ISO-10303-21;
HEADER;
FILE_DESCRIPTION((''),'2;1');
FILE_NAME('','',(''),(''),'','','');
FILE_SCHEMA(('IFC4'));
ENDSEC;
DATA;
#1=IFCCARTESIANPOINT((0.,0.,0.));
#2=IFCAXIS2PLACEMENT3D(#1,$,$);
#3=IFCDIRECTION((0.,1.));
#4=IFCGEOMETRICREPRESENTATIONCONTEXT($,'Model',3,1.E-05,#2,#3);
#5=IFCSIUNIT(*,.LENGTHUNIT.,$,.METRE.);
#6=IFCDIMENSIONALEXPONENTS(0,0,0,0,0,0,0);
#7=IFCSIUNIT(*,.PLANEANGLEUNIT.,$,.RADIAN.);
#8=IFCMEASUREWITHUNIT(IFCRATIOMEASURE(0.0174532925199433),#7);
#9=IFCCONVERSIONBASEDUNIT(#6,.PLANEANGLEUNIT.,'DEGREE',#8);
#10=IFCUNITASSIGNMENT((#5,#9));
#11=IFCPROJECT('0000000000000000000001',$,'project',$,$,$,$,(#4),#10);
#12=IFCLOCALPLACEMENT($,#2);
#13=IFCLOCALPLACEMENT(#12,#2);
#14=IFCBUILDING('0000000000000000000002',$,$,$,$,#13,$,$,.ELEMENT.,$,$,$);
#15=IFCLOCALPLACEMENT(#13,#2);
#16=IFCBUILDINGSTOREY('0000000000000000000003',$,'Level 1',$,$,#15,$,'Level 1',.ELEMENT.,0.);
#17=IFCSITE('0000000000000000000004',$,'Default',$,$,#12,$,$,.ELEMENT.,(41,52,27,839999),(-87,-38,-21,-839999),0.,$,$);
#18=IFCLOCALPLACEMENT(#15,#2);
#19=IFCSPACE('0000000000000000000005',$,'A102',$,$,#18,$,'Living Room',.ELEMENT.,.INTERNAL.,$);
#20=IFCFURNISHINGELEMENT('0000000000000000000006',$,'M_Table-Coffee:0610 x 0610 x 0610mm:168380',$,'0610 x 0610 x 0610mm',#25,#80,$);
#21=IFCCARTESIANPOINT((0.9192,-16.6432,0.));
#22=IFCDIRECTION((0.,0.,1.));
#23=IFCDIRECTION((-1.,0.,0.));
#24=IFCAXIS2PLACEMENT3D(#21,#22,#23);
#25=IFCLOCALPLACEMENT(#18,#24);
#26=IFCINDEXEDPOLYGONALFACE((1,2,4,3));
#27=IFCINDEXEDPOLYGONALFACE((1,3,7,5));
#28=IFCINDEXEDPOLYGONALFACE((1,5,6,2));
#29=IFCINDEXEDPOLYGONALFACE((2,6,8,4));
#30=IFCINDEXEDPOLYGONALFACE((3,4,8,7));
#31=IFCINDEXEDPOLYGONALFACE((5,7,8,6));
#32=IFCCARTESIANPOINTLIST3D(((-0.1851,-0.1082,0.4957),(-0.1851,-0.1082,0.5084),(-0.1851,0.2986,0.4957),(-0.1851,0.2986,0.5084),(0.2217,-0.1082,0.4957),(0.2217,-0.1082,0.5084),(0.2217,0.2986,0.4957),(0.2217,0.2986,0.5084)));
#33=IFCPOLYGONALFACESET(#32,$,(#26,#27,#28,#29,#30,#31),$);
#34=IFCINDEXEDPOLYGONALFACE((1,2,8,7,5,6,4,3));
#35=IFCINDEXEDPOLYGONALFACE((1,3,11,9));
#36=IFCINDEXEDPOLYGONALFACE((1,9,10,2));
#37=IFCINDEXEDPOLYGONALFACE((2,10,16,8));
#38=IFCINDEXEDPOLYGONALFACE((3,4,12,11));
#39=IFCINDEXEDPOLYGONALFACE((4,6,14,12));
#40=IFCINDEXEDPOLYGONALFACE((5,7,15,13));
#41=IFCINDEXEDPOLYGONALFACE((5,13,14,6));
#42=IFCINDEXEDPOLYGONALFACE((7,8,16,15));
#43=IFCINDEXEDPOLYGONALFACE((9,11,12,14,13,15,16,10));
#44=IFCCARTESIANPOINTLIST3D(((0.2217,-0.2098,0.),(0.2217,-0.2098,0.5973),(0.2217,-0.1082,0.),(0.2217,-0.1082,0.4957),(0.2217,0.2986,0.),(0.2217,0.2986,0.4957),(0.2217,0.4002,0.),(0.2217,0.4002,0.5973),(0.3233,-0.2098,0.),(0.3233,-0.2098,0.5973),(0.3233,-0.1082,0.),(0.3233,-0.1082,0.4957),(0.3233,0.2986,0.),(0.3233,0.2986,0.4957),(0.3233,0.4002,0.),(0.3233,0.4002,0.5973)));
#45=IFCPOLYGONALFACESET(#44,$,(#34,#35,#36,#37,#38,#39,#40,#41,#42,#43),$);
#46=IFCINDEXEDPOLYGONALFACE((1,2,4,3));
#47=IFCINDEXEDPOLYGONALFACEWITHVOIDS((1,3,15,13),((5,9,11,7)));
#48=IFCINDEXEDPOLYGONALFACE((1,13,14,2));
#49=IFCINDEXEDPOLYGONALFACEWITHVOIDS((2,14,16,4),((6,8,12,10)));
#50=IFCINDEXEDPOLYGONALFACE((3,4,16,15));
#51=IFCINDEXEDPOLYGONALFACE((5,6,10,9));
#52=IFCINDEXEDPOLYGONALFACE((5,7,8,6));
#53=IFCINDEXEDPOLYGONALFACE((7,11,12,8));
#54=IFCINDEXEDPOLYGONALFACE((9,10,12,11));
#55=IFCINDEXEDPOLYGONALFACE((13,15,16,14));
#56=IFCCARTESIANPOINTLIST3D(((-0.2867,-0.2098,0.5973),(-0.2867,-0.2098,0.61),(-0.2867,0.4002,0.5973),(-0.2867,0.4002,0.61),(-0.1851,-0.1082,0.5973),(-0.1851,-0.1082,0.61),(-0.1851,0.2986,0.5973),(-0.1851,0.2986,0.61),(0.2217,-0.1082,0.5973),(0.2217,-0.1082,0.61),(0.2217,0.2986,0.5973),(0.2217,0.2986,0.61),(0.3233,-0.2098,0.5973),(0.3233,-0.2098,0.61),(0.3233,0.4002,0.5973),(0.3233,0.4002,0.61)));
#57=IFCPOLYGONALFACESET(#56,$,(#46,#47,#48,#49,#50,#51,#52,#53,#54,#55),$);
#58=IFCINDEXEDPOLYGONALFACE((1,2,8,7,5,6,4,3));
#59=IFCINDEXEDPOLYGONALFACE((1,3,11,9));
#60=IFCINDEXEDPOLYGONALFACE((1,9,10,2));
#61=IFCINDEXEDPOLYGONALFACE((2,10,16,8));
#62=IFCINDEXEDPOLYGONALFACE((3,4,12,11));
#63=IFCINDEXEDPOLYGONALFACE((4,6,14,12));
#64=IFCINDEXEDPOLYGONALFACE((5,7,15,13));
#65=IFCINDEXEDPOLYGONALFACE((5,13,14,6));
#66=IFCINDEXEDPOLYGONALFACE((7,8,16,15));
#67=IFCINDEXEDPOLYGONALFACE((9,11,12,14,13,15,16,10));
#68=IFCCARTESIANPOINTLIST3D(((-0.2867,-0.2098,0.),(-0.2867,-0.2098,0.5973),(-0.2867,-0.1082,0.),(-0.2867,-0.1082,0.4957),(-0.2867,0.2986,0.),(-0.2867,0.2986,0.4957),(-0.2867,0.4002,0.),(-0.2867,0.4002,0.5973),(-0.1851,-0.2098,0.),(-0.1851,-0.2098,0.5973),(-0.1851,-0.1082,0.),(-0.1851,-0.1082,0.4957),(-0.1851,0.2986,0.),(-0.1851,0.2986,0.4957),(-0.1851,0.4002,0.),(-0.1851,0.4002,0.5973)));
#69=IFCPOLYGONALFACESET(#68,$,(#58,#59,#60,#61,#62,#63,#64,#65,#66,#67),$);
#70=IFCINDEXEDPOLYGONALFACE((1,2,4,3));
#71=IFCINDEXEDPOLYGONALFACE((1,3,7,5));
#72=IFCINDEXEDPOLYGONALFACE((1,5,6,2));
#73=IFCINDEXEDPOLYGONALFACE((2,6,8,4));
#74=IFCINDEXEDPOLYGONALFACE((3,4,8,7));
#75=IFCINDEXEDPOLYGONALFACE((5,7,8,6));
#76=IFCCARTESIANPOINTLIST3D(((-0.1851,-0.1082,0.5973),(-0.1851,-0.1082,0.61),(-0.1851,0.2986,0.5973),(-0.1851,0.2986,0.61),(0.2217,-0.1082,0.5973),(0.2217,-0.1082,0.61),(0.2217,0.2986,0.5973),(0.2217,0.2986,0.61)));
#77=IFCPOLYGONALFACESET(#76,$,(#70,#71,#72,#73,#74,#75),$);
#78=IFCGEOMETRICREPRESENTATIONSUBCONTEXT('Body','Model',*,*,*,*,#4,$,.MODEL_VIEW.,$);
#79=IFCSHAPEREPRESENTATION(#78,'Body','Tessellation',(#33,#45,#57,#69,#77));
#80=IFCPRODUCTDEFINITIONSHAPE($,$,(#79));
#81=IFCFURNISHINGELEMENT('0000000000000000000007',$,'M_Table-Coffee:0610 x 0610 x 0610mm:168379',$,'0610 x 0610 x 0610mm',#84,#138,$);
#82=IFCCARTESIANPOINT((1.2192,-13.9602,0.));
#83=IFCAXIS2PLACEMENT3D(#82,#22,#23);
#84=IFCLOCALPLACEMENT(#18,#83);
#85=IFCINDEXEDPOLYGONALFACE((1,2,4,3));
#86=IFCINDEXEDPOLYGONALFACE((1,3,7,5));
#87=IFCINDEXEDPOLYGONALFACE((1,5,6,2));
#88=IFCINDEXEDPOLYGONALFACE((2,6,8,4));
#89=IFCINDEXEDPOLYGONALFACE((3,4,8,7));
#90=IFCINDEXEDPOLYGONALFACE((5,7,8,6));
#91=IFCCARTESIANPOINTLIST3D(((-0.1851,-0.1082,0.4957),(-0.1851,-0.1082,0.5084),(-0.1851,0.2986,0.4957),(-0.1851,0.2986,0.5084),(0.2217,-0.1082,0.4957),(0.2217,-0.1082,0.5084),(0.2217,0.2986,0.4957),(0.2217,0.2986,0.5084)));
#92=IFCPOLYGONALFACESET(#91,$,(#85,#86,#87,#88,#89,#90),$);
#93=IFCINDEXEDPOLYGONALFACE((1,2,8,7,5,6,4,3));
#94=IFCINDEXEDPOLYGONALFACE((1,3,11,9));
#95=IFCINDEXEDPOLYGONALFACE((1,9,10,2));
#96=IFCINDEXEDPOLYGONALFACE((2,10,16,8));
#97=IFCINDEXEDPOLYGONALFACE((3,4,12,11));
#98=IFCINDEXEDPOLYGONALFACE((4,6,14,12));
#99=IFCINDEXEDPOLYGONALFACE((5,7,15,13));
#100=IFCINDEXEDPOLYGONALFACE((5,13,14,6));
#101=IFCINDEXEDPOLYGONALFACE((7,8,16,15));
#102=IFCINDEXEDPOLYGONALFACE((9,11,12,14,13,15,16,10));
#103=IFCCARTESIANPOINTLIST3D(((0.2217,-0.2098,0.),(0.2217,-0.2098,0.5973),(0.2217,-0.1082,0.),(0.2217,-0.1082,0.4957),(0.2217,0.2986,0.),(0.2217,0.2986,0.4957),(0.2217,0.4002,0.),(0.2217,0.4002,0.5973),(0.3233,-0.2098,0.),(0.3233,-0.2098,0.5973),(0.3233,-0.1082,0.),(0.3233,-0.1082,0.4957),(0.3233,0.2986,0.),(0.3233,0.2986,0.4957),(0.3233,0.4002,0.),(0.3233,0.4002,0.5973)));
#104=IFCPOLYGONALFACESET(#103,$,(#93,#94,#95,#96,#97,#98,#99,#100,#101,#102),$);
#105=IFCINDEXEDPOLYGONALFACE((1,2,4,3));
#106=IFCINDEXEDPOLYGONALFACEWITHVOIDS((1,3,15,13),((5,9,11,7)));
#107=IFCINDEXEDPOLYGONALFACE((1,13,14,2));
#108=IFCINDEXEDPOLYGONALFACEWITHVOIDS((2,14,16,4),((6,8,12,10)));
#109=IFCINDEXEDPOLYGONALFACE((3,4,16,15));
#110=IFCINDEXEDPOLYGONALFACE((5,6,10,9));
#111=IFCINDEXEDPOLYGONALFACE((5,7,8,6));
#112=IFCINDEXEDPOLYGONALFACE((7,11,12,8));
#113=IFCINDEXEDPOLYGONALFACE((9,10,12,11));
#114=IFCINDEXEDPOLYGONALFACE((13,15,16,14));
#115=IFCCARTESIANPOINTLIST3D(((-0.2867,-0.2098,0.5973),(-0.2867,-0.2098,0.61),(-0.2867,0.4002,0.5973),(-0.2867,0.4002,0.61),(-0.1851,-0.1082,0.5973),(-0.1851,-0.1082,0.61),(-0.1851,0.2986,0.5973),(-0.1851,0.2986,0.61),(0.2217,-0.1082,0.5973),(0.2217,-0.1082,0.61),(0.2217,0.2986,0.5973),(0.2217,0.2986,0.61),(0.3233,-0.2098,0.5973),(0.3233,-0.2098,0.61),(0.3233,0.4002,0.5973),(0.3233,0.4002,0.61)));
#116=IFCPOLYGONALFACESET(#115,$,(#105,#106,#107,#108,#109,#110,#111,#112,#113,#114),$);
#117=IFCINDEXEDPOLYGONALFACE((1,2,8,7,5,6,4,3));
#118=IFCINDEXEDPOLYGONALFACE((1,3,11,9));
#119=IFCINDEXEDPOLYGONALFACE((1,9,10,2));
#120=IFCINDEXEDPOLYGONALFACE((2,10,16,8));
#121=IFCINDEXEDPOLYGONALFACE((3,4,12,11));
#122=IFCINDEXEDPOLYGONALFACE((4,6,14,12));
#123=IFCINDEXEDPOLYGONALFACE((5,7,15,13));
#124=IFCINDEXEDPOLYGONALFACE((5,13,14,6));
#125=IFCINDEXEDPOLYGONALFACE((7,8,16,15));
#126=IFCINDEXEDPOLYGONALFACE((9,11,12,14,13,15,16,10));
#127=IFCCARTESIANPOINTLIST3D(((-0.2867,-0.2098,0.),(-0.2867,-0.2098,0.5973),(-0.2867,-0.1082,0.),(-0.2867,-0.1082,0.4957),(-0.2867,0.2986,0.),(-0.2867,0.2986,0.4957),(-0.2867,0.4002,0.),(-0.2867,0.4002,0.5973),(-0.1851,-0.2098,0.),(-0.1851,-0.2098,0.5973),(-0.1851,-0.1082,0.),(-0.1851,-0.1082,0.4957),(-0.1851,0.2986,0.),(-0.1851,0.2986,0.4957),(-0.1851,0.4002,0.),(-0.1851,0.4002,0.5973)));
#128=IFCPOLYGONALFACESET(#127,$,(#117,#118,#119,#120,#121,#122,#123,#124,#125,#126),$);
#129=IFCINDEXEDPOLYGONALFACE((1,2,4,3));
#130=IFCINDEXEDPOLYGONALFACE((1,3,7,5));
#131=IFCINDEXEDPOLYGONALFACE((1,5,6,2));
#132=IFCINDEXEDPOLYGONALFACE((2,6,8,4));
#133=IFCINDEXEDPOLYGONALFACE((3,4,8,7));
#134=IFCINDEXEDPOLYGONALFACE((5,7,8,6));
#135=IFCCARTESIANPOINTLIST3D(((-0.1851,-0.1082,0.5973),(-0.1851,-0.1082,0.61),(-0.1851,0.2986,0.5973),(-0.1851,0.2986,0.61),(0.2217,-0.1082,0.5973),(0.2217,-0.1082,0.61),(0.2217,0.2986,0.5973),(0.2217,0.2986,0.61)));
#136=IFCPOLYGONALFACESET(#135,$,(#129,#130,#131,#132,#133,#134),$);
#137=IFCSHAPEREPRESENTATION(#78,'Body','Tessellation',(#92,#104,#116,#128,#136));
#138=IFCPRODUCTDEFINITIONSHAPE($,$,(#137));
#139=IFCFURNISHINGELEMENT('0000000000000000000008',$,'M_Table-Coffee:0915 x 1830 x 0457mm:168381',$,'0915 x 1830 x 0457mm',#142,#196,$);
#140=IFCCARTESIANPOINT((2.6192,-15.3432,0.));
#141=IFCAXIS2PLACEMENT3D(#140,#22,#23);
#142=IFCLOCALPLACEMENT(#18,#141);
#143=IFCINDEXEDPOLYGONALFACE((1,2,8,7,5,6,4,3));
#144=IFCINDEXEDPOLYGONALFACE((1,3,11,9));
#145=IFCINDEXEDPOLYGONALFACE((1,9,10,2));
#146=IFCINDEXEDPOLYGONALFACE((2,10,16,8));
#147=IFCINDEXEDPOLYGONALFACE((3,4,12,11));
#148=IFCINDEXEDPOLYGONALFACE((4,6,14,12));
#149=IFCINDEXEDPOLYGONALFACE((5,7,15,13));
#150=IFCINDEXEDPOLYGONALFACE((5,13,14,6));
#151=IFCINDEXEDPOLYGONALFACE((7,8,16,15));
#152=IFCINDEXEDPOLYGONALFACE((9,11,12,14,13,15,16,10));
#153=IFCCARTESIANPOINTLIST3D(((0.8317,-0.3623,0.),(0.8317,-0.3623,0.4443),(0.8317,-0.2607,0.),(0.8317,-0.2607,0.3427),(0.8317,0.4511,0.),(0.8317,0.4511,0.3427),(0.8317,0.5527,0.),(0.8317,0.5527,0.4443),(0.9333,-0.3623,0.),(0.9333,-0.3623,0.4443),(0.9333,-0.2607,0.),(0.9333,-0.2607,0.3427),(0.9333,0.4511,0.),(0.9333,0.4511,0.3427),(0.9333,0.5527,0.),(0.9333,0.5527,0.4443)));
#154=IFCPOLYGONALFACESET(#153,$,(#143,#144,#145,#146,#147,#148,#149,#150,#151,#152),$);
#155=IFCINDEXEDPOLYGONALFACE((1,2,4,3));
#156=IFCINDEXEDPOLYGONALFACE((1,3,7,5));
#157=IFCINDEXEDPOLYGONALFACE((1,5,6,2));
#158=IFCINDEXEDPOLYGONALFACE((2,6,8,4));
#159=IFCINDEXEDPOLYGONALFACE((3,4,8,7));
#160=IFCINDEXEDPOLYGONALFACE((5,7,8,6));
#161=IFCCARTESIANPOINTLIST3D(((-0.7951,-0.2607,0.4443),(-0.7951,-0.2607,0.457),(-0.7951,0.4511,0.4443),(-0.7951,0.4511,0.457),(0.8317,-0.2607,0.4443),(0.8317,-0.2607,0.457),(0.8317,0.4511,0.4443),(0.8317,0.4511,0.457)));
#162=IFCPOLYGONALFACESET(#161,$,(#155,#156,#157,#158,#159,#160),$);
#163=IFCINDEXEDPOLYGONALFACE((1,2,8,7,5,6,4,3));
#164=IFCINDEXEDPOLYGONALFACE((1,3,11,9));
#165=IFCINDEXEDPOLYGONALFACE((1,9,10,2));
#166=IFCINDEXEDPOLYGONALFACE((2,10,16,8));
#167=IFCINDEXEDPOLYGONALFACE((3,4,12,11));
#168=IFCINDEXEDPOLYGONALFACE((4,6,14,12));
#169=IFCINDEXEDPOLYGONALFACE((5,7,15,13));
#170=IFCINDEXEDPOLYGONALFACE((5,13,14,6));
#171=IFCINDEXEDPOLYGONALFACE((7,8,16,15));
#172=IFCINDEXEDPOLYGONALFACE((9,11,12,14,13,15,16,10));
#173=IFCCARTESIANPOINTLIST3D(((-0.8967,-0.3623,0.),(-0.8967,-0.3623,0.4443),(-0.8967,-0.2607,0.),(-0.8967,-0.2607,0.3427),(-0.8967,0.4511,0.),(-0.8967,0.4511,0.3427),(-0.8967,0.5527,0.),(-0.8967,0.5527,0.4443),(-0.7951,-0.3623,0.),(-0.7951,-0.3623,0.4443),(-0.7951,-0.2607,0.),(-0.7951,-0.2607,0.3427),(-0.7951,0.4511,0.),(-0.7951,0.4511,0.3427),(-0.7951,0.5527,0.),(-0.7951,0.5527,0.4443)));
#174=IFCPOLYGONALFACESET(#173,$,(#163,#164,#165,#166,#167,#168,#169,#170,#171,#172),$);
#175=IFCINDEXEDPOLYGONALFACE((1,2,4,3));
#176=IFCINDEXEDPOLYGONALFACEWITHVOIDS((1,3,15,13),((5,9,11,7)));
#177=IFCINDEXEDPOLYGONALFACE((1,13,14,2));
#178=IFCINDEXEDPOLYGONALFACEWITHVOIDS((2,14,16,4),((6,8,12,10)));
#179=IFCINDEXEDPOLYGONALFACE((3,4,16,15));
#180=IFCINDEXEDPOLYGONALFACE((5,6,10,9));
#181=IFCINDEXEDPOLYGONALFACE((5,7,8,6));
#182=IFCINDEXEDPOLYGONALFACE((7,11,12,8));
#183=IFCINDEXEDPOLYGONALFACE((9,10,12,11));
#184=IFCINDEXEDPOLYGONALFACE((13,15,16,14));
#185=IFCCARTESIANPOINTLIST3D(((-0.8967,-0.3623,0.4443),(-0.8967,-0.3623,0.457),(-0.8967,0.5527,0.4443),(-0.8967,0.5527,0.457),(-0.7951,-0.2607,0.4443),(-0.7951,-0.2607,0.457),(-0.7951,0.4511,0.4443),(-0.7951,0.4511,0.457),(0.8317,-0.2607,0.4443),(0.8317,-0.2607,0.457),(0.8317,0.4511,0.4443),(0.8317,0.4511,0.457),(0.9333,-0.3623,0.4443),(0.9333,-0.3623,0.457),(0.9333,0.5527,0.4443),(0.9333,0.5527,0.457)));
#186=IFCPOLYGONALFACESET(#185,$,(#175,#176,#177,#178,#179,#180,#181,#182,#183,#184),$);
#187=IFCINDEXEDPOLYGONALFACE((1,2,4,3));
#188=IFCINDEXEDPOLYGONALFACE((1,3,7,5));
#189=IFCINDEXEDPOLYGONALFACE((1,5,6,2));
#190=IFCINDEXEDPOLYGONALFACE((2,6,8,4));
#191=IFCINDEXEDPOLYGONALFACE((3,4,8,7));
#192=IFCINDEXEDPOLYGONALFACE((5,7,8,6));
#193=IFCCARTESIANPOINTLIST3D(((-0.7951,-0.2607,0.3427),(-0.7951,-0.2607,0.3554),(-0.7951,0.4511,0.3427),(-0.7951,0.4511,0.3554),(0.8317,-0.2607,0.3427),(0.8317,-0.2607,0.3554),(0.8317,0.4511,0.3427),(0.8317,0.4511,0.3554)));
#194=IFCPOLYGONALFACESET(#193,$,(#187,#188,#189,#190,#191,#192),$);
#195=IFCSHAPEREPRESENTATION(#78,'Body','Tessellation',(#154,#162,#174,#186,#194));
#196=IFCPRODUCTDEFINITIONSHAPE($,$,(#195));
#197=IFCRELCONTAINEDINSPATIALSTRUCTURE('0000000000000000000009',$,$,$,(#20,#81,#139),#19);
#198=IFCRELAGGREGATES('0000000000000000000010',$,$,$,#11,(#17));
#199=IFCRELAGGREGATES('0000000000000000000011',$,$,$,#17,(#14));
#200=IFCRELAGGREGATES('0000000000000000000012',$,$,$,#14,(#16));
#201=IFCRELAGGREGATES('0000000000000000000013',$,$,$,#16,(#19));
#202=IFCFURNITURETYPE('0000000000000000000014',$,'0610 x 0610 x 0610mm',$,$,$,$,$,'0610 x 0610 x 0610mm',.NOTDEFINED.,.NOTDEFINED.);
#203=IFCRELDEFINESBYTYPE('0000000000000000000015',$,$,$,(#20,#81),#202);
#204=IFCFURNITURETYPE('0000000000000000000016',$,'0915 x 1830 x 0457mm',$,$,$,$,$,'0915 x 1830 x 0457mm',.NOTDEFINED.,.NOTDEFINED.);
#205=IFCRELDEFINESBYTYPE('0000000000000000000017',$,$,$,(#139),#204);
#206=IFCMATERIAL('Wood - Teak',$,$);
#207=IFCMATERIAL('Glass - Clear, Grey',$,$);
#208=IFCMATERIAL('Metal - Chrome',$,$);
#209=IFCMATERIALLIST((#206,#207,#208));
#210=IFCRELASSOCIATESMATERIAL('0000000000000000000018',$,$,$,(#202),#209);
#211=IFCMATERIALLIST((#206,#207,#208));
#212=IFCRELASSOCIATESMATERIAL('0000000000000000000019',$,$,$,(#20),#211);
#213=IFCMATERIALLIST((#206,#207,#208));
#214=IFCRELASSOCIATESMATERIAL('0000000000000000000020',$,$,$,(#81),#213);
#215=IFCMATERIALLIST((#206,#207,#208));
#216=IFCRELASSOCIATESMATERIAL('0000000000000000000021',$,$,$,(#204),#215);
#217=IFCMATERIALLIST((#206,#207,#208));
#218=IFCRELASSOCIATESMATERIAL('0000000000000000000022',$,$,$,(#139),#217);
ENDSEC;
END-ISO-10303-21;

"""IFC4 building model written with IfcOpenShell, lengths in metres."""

from ifc_helpers import new_model, entity, si_unit, converted_unit, direction, frame, origin, origin_2d_with_axis, place, context, subcontext, project, spatial, polyline, rectangle, outline, extrude, source, transform, mapped, material, material_list, type_object, type_shapes, element, save


model = new_model("IFC4")

# Units and contexts
model_context = context("Model", 3, precision=1e-05, world=origin(), true_north=direction((0.0, 1.0)))
body_context = subcontext(model_context, "Body", "Model", "MODEL_VIEW")
ifc_project = project(units=[si_unit("LENGTHUNIT", "METRE"), converted_unit("PLANEANGLEUNIT", "DEGREE", entity("IfcRatioMeasure", 0.0174532925199433), si_unit("PLANEANGLEUNIT", "RADIAN"), dimensions=[0, 0, 0, 0, 0, 0, 0])], contexts=[model_context])

# Site, building, storey
site_placement = place(None, origin())
site = spatial("IfcSite", under=ifc_project, at=site_placement, Name="Default", CompositionType="ELEMENT", RefLatitude=(41, 52, 27, 839999), RefLongitude=(-87, -38, -21, -839999), RefElevation=0.0)
building_placement = place(site_placement, origin())
building = spatial("IfcBuilding", under=site, at=building_placement, CompositionType="ELEMENT")
storey_placement = place(building_placement, origin())
storey = spatial("IfcBuildingStorey", under=building, at=storey_placement, Name="Level 1", LongName="Level 1", CompositionType="ELEMENT", Elevation=0.0)

# Shared definitions
space_1_placement = place(storey_placement, origin())
space_1 = spatial("IfcSpace", under=storey, at=space_1_placement, Name="A102", LongName="Living Room", CompositionType="ELEMENT", PredefinedType="INTERNAL")

# Furnishing elements
ifc_material_1 = material(Name="Wood - Teak")
ifc_material_2 = material(Name="Glass - Clear, Grey")
ifc_material_3 = material(Name="Metal - Chrome")
ifc_material_list_1 = material_list([ifc_material_1, ifc_material_2, ifc_material_3])
ifc_material_list_2 = material_list([ifc_material_1, ifc_material_2, ifc_material_3])
furniture_type_1 = type_object("IfcFurnitureType", Name="0610 x 0610 x 0610mm", ElementType="0610 x 0610 x 0610mm", AssemblyPlace="NOTDEFINED", material=ifc_material_list_2)
shared_shape_1 = source(origin(), body_context, "Body", "SweptSolid", [
    extrude(rectangle(XDim=0.4068, YDim=0.4068, at=origin_2d_with_axis()), frame((0.0183, 0.0952, 0.4957), z_axis=(0.0, 0.0, 1.0), x_axis=(-1.0, 0.0, 0.0)), (0.0, 0.0, 1.0), 0.0127),
    extrude(outline(polyline([(-0.2732, -0.305), (0.324, -0.305), (0.324, 0.305), (-0.2732, 0.305), (-0.2732, 0.2034), (0.2225, 0.2034), (0.2225, -0.2034), (-0.2732, -0.2034), (-0.2732, -0.305)])), frame((0.2217, 0.0952, 0.2732), z_axis=(1.0, 0.0, 0.0), x_axis=(0.0, 0.0, 1.0)), (0.0, 0.0, 1.0), 0.1016),
    extrude(outline(polyline([(-0.305, -0.305), (0.305, -0.305), (0.305, 0.305), (-0.305, 0.305), (-0.305, -0.305)]), holes=[polyline([(-0.2034, -0.2034), (-0.2034, 0.2034), (0.2034, 0.2034), (0.2034, -0.2034), (-0.2034, -0.2034)])]), frame((0.0183, 0.0952, 0.5973), z_axis=(0.0, 0.0, 1.0), x_axis=(-1.0, 0.0, 0.0)), (0.0, 0.0, 1.0), 0.0127),
    extrude(outline(polyline([(-0.305, -0.3241), (0.305, -0.3241), (0.305, 0.2733), (0.2034, 0.2733), (0.2034, -0.2224), (-0.2034, -0.2224), (-0.2034, 0.2733), (-0.305, 0.2733), (-0.305, -0.3241)])), frame((-0.2867, 0.0952, 0.2733), z_axis=(1.0, 0.0, 0.0), x_axis=(0.0, -1.0, 0.0)), (0.0, 0.0, 1.0), 0.1016),
    extrude(rectangle(XDim=0.4068, YDim=0.4068, at=origin_2d_with_axis()), frame((0.0183, 0.0952, 0.5973), z_axis=(0.0, 0.0, 1.0), x_axis=(-1.0, 0.0, 0.0)), (0.0, 0.0, 1.0), 0.0127),
])
type_shapes(furniture_type_1, [shared_shape_1])
furnishing_1_placement = place(space_1_placement, frame((0.9192, -16.6432, 0.0), z_axis=(0.0, 0.0, 1.0), x_axis=(-1.0, 0.0, 0.0)))
element("IfcFurnishingElement", 1, at=furnishing_1_placement, inside=space_1, type_object=furniture_type_1, material=ifc_material_list_1, Name="M_Table-Coffee:0610 x 0610 x 0610mm:168380", ObjectType="0610 x 0610 x 0610mm", context=body_context, shape_type="MappedRepresentation", body=[
    mapped(shared_shape_1, transform((0.0, 0.0, 0.0), scale=1.0)),
])
ifc_material_list_3 = material_list([ifc_material_1, ifc_material_2, ifc_material_3])
furnishing_2_placement = place(space_1_placement, frame((1.2192, -13.9602, 0.0), z_axis=(0.0, 0.0, 1.0), x_axis=(-1.0, 0.0, 0.0)))
element("IfcFurnishingElement", 2, at=furnishing_2_placement, inside=space_1, type_object=furniture_type_1, material=ifc_material_list_3, Name="M_Table-Coffee:0610 x 0610 x 0610mm:168379", ObjectType="0610 x 0610 x 0610mm", context=body_context, shape_type="MappedRepresentation", body=[
    mapped(shared_shape_1, transform((0.0, 0.0, 0.0), scale=1.0)),
])
ifc_material_list_4 = material_list([ifc_material_1, ifc_material_2, ifc_material_3])
ifc_material_list_5 = material_list([ifc_material_1, ifc_material_2, ifc_material_3])
furniture_type_2 = type_object("IfcFurnitureType", Name="0915 x 1830 x 0457mm", ElementType="0915 x 1830 x 0457mm", AssemblyPlace="NOTDEFINED", material=ifc_material_list_5)
shared_shape_2 = source(origin(), body_context, "Body", "SweptSolid", [
    extrude(outline(polyline([(-0.1967, -0.4575), (0.2475, -0.4575), (0.2475, 0.4575), (-0.1967, 0.4575), (-0.1967, 0.3559), (0.146, 0.3559), (0.146, -0.3559), (-0.1967, -0.3559), (-0.1967, -0.4575)])), frame((0.8317, 0.0952, 0.1967), z_axis=(1.0, 0.0, 0.0), x_axis=(0.0, 0.0, 1.0)), (0.0, 0.0, 1.0), 0.1016),
    extrude(rectangle(XDim=1.6268, YDim=0.7118, at=origin_2d_with_axis()), frame((0.0183, 0.0952, 0.4443), z_axis=(0.0, 0.0, 1.0), x_axis=(-1.0, 0.0, 0.0)), (0.0, 0.0, 1.0), 0.0127),
    extrude(outline(polyline([(-0.4575, -0.2476), (0.4575, -0.2476), (0.4575, 0.1968), (0.3559, 0.1968), (0.3559, -0.1459), (-0.3559, -0.1459), (-0.3559, 0.1968), (-0.4575, 0.1968), (-0.4575, -0.2476)])), frame((-0.8967, 0.0952, 0.1968), z_axis=(1.0, 0.0, 0.0), x_axis=(0.0, -1.0, 0.0)), (0.0, 0.0, 1.0), 0.1016),
    extrude(outline(polyline([(-0.915, -0.4575), (0.915, -0.4575), (0.915, 0.4575), (-0.915, 0.4575), (-0.915, -0.4575)]), holes=[polyline([(-0.8134, -0.3559), (-0.8134, 0.3559), (0.8134, 0.3559), (0.8134, -0.3559), (-0.8134, -0.3559)])]), frame((0.0183, 0.0952, 0.4443), z_axis=(0.0, 0.0, 1.0), x_axis=(-1.0, 0.0, 0.0)), (0.0, 0.0, 1.0), 0.0127),
    extrude(rectangle(XDim=1.6268, YDim=0.7118, at=origin_2d_with_axis()), frame((0.0183, 0.0952, 0.3427), z_axis=(0.0, 0.0, 1.0), x_axis=(-1.0, 0.0, 0.0)), (0.0, 0.0, 1.0), 0.0127),
])
type_shapes(furniture_type_2, [shared_shape_2])
furnishing_3_placement = place(space_1_placement, frame((2.6192, -15.3432, 0.0), z_axis=(0.0, 0.0, 1.0), x_axis=(-1.0, 0.0, 0.0)))
element("IfcFurnishingElement", 3, at=furnishing_3_placement, inside=space_1, type_object=furniture_type_2, material=ifc_material_list_4, Name="M_Table-Coffee:0915 x 1830 x 0457mm:168381", ObjectType="0915 x 1830 x 0457mm", context=body_context, shape_type="MappedRepresentation", body=[
    mapped(shared_shape_2, transform((0.0, 0.0, 0.0), scale=1.0)),
])

save(model, "model.ifc")
